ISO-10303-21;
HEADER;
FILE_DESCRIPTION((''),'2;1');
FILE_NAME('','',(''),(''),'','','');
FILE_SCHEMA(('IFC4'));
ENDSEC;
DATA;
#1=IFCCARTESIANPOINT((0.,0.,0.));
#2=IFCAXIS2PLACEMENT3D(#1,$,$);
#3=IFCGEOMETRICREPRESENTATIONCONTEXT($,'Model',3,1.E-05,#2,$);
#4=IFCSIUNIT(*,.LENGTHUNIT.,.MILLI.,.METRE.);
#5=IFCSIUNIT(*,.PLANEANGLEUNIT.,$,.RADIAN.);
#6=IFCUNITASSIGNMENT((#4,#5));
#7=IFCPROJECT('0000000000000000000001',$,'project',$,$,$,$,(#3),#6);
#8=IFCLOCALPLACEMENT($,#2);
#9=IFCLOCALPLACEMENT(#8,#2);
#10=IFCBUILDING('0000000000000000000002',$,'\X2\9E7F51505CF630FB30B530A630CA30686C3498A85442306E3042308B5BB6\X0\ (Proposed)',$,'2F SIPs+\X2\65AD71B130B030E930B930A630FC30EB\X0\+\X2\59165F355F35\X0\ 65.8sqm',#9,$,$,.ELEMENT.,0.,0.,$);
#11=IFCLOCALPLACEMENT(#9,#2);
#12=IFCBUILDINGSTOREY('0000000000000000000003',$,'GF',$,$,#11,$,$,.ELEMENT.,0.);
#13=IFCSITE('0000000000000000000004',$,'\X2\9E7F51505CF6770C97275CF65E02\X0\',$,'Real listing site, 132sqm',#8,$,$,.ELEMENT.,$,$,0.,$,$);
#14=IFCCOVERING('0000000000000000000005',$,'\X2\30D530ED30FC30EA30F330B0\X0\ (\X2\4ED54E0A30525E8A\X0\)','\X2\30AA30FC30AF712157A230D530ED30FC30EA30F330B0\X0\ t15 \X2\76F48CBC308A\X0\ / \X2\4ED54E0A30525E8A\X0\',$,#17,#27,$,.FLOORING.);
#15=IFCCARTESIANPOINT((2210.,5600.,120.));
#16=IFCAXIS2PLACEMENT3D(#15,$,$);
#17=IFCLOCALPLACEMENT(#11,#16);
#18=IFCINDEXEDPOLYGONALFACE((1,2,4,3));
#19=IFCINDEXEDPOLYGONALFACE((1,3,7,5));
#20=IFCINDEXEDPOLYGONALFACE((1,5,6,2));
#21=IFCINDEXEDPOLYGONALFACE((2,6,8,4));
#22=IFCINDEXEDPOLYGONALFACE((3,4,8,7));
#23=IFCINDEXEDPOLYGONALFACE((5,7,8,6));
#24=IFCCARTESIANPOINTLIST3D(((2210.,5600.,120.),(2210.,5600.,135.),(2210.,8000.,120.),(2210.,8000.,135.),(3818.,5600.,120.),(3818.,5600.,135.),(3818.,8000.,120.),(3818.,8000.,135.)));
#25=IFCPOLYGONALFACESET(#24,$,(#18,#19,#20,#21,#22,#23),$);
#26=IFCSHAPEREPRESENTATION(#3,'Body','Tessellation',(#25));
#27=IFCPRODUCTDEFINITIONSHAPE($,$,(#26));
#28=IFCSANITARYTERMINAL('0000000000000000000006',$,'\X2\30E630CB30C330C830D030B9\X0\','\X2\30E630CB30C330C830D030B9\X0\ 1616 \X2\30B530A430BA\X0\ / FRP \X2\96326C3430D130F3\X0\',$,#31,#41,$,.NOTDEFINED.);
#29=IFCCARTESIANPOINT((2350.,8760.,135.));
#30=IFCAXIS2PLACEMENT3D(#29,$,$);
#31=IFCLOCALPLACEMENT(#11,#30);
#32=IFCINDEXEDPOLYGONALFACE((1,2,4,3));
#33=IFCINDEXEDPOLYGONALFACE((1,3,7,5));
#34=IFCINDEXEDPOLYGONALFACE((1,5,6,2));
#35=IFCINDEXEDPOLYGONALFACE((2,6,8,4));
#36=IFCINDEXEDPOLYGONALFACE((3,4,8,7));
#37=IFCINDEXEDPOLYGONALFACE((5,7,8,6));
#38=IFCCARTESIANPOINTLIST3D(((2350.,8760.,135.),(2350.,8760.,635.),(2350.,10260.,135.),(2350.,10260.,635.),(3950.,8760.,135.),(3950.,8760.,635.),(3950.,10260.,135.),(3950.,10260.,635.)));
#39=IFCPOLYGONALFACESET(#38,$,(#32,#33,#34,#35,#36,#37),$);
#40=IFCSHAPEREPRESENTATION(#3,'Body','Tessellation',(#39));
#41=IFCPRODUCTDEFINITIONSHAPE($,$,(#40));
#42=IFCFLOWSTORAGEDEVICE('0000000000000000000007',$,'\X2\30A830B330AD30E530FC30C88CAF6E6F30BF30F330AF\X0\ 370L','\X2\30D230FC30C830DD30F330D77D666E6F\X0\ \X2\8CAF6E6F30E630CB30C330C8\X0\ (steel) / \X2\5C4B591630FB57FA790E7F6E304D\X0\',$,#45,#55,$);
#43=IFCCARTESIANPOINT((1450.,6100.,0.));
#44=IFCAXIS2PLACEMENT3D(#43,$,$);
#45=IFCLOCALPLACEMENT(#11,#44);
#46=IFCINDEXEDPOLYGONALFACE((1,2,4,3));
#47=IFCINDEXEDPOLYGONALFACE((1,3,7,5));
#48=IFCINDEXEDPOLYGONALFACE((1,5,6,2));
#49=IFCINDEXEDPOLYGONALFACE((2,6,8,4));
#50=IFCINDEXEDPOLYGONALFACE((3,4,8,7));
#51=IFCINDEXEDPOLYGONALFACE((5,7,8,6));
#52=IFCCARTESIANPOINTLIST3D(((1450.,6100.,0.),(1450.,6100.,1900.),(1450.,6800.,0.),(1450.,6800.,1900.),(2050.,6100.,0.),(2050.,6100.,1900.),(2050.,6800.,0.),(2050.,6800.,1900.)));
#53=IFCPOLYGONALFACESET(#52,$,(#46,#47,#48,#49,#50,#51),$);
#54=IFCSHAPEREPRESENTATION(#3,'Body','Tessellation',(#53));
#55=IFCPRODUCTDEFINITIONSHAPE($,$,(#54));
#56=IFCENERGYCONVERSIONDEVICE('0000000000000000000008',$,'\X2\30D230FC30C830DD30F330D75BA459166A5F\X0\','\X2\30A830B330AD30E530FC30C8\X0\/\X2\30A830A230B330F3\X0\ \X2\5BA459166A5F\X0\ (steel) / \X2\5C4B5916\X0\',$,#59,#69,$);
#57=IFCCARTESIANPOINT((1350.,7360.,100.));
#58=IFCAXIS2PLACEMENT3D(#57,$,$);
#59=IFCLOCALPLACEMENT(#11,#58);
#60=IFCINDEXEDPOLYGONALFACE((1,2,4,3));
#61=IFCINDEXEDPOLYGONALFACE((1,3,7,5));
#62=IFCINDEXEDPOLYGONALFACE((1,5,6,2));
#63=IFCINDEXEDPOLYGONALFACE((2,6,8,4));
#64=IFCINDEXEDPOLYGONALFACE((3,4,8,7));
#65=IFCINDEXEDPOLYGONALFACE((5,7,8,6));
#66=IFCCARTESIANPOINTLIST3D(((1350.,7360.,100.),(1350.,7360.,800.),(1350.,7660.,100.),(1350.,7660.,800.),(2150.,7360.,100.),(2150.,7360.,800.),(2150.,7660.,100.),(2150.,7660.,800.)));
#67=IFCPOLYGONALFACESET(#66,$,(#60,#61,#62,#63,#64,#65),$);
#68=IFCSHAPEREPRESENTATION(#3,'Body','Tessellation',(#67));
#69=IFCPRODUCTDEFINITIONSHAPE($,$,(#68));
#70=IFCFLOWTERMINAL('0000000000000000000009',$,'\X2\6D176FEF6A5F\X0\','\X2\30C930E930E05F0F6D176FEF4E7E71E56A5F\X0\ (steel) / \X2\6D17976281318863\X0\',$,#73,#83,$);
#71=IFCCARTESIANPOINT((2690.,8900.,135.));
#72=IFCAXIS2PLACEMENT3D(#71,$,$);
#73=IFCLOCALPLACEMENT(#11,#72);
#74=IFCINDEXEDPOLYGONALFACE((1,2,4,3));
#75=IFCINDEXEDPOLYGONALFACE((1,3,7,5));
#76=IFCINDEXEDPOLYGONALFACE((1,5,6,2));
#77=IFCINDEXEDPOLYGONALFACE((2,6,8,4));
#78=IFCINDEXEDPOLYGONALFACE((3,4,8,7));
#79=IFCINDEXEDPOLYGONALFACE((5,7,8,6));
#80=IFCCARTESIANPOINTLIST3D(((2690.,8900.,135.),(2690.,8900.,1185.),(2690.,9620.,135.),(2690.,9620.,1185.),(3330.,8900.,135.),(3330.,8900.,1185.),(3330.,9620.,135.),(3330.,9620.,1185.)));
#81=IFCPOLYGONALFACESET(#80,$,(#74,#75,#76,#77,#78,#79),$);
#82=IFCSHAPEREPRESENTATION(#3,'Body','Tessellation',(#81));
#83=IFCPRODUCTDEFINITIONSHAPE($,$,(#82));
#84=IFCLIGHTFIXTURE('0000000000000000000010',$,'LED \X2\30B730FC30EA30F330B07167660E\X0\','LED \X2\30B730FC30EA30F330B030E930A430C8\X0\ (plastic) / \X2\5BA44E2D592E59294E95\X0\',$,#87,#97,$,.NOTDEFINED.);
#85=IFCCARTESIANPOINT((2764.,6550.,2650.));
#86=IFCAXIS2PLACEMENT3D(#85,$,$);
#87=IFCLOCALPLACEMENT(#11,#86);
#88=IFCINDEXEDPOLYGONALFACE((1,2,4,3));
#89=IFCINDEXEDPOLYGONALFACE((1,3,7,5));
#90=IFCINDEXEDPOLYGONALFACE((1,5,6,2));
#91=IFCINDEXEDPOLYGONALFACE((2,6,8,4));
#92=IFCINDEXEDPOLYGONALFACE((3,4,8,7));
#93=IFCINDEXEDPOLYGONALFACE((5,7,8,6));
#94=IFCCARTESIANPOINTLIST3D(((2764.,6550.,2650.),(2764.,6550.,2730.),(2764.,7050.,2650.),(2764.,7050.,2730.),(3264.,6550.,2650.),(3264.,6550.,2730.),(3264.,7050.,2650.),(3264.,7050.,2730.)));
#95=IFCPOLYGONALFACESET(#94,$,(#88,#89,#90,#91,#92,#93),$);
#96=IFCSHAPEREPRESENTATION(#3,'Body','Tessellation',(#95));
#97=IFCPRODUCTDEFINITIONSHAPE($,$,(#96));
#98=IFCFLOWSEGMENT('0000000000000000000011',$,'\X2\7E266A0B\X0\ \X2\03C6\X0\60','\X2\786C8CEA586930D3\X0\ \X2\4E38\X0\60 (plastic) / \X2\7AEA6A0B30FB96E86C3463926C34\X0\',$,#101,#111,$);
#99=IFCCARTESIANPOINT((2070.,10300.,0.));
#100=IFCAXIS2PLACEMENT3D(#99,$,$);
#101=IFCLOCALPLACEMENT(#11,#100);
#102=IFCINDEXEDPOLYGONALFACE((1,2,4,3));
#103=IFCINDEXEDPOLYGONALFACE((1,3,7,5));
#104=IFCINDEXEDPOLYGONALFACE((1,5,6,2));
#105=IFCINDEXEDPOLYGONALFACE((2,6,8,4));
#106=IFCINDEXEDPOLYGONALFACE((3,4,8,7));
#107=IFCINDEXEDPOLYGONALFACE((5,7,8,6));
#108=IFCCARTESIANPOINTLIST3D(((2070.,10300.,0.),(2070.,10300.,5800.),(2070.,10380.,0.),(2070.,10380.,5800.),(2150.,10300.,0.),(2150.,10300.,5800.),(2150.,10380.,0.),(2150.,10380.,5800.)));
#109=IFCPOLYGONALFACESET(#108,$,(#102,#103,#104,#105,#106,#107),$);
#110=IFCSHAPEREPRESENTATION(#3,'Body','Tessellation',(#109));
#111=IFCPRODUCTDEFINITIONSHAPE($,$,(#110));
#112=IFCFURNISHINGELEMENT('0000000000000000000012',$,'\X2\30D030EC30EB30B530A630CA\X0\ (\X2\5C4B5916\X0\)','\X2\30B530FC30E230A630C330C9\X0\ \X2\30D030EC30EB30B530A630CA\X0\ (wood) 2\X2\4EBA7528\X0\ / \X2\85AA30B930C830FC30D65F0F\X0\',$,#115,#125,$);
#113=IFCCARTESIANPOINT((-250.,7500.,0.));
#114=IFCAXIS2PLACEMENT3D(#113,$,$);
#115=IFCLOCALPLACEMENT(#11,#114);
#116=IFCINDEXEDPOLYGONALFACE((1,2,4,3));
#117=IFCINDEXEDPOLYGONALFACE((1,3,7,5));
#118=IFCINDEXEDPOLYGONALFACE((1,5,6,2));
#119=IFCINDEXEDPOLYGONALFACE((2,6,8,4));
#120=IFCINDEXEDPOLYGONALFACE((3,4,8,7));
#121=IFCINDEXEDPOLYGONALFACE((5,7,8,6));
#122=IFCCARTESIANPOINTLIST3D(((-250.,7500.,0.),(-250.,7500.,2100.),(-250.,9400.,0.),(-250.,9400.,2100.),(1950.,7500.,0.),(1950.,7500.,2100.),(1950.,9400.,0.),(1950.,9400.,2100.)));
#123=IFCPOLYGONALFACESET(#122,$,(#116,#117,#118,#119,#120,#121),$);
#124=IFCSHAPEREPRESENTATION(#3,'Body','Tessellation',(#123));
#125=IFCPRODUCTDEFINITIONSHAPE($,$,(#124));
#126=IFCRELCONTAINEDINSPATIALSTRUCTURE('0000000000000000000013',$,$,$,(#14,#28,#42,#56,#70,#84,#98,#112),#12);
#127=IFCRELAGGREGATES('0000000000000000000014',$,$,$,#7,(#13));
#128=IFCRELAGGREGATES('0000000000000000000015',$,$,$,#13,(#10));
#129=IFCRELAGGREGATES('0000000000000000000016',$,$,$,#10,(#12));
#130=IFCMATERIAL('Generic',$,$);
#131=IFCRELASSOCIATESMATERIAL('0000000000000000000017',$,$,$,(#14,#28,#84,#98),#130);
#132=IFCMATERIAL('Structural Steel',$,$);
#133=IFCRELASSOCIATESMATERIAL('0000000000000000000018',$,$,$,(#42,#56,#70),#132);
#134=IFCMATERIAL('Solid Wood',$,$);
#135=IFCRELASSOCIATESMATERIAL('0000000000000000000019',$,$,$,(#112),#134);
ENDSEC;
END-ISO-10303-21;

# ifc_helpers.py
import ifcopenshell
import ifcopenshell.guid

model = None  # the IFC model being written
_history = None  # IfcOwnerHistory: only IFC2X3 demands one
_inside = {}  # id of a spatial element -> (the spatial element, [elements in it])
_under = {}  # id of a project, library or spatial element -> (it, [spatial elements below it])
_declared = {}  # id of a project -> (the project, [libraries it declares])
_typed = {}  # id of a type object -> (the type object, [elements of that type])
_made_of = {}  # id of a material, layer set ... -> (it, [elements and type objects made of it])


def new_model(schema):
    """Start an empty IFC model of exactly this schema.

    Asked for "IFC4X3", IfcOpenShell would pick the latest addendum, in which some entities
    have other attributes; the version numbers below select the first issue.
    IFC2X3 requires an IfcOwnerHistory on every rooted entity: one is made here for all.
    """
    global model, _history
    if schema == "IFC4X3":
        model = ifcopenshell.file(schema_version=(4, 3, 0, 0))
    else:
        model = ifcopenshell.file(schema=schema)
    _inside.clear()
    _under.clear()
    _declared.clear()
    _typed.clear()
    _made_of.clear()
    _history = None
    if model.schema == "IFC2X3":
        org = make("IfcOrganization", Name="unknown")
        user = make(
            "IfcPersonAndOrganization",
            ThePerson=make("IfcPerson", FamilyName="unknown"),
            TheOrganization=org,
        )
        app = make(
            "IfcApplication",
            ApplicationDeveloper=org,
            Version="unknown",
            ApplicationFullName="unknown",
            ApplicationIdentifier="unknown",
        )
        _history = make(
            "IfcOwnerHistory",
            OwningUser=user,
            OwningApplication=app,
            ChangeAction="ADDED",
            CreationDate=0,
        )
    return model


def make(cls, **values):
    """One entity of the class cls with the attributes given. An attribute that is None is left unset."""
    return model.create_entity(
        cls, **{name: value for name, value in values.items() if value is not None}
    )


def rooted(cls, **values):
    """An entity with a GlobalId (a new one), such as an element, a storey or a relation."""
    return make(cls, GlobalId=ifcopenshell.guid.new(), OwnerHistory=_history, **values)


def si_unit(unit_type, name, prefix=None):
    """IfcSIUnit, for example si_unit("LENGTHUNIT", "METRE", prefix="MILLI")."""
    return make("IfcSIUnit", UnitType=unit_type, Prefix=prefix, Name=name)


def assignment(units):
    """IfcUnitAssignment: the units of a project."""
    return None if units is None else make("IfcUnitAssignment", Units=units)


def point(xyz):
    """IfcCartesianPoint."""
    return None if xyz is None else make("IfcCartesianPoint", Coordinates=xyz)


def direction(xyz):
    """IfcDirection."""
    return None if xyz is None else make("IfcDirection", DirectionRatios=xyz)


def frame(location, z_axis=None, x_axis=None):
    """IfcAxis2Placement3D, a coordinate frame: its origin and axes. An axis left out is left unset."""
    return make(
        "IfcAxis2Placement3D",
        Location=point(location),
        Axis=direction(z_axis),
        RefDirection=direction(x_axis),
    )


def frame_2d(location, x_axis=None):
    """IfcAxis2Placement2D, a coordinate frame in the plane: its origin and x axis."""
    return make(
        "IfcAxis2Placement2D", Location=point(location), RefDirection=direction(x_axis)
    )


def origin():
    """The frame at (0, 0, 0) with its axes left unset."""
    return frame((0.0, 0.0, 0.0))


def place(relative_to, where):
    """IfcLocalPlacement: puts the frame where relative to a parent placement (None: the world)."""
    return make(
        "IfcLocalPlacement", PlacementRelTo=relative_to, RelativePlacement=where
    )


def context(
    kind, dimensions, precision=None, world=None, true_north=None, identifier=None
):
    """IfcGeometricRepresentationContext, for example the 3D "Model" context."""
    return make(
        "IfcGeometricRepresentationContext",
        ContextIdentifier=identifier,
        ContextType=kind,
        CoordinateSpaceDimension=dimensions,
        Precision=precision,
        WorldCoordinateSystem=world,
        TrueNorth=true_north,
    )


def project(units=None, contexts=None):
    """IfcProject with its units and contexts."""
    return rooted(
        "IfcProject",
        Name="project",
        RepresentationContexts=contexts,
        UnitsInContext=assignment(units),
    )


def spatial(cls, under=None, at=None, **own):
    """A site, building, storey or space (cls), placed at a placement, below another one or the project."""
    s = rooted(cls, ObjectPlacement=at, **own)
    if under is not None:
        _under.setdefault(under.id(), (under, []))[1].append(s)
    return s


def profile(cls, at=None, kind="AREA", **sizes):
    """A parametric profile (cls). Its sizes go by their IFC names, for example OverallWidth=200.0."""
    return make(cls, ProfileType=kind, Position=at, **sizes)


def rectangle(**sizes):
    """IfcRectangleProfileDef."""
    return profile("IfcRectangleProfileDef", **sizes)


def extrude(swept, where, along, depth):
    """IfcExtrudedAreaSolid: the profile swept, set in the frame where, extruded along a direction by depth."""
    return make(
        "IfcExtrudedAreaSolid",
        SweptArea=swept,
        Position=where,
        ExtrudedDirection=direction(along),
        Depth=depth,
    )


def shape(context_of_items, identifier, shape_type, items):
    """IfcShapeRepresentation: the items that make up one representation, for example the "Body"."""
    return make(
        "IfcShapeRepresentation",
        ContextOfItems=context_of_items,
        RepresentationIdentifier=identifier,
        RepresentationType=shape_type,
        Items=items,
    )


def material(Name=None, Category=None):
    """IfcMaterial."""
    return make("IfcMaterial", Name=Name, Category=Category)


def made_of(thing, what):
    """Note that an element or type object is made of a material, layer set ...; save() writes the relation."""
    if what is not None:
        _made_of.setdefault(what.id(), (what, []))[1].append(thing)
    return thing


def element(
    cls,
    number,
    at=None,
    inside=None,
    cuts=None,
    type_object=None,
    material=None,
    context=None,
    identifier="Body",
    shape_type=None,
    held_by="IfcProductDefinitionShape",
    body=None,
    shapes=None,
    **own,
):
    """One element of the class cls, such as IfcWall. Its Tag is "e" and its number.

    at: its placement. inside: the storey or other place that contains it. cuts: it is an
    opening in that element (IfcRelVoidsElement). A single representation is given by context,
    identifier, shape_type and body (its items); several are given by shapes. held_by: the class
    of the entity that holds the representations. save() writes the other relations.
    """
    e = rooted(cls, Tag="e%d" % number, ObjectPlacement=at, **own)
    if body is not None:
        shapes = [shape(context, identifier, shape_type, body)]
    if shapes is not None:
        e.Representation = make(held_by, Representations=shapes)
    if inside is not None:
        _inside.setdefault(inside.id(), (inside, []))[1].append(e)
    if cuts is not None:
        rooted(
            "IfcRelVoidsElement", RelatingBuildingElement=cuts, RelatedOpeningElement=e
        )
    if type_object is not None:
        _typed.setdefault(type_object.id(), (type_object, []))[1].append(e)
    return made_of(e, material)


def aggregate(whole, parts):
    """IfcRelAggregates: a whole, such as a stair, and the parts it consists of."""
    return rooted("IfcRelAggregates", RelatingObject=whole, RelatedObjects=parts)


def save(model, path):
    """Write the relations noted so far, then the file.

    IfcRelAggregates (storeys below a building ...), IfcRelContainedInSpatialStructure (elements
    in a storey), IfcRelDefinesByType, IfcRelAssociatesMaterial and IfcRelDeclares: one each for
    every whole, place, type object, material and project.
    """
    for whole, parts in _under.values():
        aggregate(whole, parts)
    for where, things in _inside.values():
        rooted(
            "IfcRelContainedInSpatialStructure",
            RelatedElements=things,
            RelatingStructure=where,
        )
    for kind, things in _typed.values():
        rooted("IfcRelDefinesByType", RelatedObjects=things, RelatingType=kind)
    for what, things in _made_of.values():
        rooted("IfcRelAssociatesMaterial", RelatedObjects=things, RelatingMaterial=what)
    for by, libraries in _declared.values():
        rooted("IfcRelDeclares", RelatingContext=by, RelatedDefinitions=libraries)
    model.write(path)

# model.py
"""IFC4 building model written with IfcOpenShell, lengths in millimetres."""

from ifc_helpers import new_model, si_unit, frame, frame_2d, origin, place, context, project, spatial, rectangle, extrude, material, element, save


model = new_model("IFC4")

# Units and contexts
model_context = context("Model", 3, precision=1e-05, world=origin())
ifc_project = project(units=[si_unit("LENGTHUNIT", "METRE", prefix="MILLI"), si_unit("PLANEANGLEUNIT", "RADIAN")], contexts=[model_context])

# Site, building, storey
site_placement = place(None, origin())
site = spatial("IfcSite", under=ifc_project, at=site_placement, Name="鹿児島県霧島市", ObjectType="Real listing site, 132sqm", CompositionType="ELEMENT", RefElevation=0.0)
building_placement = place(site_placement, origin())
building = spatial("IfcBuilding", under=site, at=building_placement, Name="鹿児島・サウナと水風呂のある家 (Proposed)", ObjectType="2F SIPs+断熱グラスウール+外張張 65.8sqm", CompositionType="ELEMENT", ElevationOfRefHeight=0.0, ElevationOfTerrain=0.0)
storey_placement = place(building_placement, origin())
storey = spatial("IfcBuildingStorey", under=building, at=storey_placement, Name="GF", CompositionType="ELEMENT", Elevation=0.0)

# Shared definitions
ifc_material_1 = material(Name="Solid Wood")

# Covering
ifc_material_2 = material(Name="Generic")
covering_1_placement = place(storey_placement, frame((2210.0, 5600.0, 120.0)))
element("IfcCovering", 1, at=covering_1_placement, inside=storey, material=ifc_material_2, Name="フローリング (仕上げ床)", Description="オーク無垢フローリング t15 直貼り / 仕上げ床", PredefinedType="FLOORING", context=model_context, shape_type="SweptSolid", body=[
    extrude(rectangle(XDim=1608.0, YDim=2400.0, at=frame_2d((804.0, 1200.0))), frame((2210.0, 5600.0, 120.0)), (0.0, 0.0, 1.0), 15.0),
])

# Sanitary terminal
sanitary_terminal_placement = place(storey_placement, frame((2350.0, 8760.0, 135.0)))
element("IfcSanitaryTerminal", 2, at=sanitary_terminal_placement, inside=storey, material=ifc_material_2, Name="ユニットバス", Description="ユニットバス 1616 サイズ / FRP 防水パン", PredefinedType="NOTDEFINED", context=model_context, shape_type="SweptSolid", body=[
    extrude(rectangle(XDim=1600.0, YDim=1500.0, at=frame_2d((800.0, 750.0))), frame((2350.0, 8760.0, 135.0)), (0.0, 0.0, 1.0), 500.0),
])

# Flow storage device
ifc_material_3 = material(Name="Structural Steel")
flow_storage_device_placement = place(storey_placement, frame((1450.0, 6100.0, 0.0)))
element("IfcFlowStorageDevice", 3, at=flow_storage_device_placement, inside=storey, material=ifc_material_3, Name="エコキュート貯湯タンク 370L", Description="ヒートポンプ給湯 貯湯ユニット (steel) / 屋外・基礎置き", context=model_context, shape_type="SweptSolid", body=[
    extrude(rectangle(XDim=600.0, YDim=700.0, at=frame_2d((300.0, 350.0))), frame((1450.0, 6100.0, 0.0)), (0.0, 0.0, 1.0), 1900.0),
])

# Energy conversion device
energy_conversion_device_placement = place(storey_placement, frame((1350.0, 7360.0, 100.0)))
element("IfcEnergyConversionDevice", 4, at=energy_conversion_device_placement, inside=storey, material=ifc_material_3, Name="ヒートポンプ室外機", Description="エコキュート/エアコン 室外機 (steel) / 屋外", context=model_context, shape_type="SweptSolid", body=[
    extrude(rectangle(XDim=800.0, YDim=300.0, at=frame_2d((400.0, 150.0))), frame((1350.0, 7360.0, 100.0)), (0.0, 0.0, 1.0), 700.0),
])

# Flow terminal
flow_terminal_placement = place(storey_placement, frame((2690.0, 8900.0, 135.0)))
element("IfcFlowTerminal", 5, at=flow_terminal_placement, inside=storey, material=ifc_material_3, Name="洗濯機", Description="ドラム式洗濯乾燥機 (steel) / 洗面脱衣", context=model_context, shape_type="SweptSolid", body=[
    extrude(rectangle(XDim=640.0, YDim=720.0, at=frame_2d((320.0, 360.0))), frame((2690.0, 8900.0, 135.0)), (0.0, 0.0, 1.0), 1050.0),
])

# Light fixture
light_fixture_placement = place(storey_placement, frame((2764.0, 6550.0, 2650.0)))
element("IfcLightFixture", 6, at=light_fixture_placement, inside=storey, material=ifc_material_2, Name="LED シーリング照明", Description="LED シーリングライト (plastic) / 室中央天井", PredefinedType="NOTDEFINED", context=model_context, shape_type="SweptSolid", body=[
    extrude(rectangle(XDim=500.0, YDim=500.0, at=frame_2d((250.0, 250.0))), frame((2764.0, 6550.0, 2650.0)), (0.0, 0.0, 1.0), 80.0),
])

# Flow segment
flow_segment_placement = place(storey_placement, frame((2070.0, 10300.0, 0.0)))
element("IfcFlowSegment", 7, at=flow_segment_placement, inside=storey, material=ifc_material_2, Name="縦樋 φ60", Description="硬質塩ビ 丸60 (plastic) / 竪樋・雨水排水", context=model_context, shape_type="SweptSolid", body=[
    extrude(rectangle(XDim=80.0, YDim=80.0, at=frame_2d((40.0, 40.0))), frame((2070.0, 10300.0, 0.0)), (0.0, 0.0, 1.0), 5800.0),
])

# Furnishing element
furnishing_placement = place(storey_placement, frame((-250.0, 7500.0, 0.0)))
element("IfcFurnishingElement", 8, at=furnishing_placement, inside=storey, material=ifc_material_1, Name="バレルサウナ (屋外)", Description="サーモウッド バレルサウナ (wood) 2人用 / 薪ストーブ式", context=model_context, shape_type="SweptSolid", body=[
    extrude(rectangle(XDim=2200.0, YDim=1900.0, at=frame_2d((1100.0, 950.0))), frame((-250.0, 7500.0, 0.0)), (0.0, 0.0, 1.0), 2100.0),
])

save(model, "model.ifc")
